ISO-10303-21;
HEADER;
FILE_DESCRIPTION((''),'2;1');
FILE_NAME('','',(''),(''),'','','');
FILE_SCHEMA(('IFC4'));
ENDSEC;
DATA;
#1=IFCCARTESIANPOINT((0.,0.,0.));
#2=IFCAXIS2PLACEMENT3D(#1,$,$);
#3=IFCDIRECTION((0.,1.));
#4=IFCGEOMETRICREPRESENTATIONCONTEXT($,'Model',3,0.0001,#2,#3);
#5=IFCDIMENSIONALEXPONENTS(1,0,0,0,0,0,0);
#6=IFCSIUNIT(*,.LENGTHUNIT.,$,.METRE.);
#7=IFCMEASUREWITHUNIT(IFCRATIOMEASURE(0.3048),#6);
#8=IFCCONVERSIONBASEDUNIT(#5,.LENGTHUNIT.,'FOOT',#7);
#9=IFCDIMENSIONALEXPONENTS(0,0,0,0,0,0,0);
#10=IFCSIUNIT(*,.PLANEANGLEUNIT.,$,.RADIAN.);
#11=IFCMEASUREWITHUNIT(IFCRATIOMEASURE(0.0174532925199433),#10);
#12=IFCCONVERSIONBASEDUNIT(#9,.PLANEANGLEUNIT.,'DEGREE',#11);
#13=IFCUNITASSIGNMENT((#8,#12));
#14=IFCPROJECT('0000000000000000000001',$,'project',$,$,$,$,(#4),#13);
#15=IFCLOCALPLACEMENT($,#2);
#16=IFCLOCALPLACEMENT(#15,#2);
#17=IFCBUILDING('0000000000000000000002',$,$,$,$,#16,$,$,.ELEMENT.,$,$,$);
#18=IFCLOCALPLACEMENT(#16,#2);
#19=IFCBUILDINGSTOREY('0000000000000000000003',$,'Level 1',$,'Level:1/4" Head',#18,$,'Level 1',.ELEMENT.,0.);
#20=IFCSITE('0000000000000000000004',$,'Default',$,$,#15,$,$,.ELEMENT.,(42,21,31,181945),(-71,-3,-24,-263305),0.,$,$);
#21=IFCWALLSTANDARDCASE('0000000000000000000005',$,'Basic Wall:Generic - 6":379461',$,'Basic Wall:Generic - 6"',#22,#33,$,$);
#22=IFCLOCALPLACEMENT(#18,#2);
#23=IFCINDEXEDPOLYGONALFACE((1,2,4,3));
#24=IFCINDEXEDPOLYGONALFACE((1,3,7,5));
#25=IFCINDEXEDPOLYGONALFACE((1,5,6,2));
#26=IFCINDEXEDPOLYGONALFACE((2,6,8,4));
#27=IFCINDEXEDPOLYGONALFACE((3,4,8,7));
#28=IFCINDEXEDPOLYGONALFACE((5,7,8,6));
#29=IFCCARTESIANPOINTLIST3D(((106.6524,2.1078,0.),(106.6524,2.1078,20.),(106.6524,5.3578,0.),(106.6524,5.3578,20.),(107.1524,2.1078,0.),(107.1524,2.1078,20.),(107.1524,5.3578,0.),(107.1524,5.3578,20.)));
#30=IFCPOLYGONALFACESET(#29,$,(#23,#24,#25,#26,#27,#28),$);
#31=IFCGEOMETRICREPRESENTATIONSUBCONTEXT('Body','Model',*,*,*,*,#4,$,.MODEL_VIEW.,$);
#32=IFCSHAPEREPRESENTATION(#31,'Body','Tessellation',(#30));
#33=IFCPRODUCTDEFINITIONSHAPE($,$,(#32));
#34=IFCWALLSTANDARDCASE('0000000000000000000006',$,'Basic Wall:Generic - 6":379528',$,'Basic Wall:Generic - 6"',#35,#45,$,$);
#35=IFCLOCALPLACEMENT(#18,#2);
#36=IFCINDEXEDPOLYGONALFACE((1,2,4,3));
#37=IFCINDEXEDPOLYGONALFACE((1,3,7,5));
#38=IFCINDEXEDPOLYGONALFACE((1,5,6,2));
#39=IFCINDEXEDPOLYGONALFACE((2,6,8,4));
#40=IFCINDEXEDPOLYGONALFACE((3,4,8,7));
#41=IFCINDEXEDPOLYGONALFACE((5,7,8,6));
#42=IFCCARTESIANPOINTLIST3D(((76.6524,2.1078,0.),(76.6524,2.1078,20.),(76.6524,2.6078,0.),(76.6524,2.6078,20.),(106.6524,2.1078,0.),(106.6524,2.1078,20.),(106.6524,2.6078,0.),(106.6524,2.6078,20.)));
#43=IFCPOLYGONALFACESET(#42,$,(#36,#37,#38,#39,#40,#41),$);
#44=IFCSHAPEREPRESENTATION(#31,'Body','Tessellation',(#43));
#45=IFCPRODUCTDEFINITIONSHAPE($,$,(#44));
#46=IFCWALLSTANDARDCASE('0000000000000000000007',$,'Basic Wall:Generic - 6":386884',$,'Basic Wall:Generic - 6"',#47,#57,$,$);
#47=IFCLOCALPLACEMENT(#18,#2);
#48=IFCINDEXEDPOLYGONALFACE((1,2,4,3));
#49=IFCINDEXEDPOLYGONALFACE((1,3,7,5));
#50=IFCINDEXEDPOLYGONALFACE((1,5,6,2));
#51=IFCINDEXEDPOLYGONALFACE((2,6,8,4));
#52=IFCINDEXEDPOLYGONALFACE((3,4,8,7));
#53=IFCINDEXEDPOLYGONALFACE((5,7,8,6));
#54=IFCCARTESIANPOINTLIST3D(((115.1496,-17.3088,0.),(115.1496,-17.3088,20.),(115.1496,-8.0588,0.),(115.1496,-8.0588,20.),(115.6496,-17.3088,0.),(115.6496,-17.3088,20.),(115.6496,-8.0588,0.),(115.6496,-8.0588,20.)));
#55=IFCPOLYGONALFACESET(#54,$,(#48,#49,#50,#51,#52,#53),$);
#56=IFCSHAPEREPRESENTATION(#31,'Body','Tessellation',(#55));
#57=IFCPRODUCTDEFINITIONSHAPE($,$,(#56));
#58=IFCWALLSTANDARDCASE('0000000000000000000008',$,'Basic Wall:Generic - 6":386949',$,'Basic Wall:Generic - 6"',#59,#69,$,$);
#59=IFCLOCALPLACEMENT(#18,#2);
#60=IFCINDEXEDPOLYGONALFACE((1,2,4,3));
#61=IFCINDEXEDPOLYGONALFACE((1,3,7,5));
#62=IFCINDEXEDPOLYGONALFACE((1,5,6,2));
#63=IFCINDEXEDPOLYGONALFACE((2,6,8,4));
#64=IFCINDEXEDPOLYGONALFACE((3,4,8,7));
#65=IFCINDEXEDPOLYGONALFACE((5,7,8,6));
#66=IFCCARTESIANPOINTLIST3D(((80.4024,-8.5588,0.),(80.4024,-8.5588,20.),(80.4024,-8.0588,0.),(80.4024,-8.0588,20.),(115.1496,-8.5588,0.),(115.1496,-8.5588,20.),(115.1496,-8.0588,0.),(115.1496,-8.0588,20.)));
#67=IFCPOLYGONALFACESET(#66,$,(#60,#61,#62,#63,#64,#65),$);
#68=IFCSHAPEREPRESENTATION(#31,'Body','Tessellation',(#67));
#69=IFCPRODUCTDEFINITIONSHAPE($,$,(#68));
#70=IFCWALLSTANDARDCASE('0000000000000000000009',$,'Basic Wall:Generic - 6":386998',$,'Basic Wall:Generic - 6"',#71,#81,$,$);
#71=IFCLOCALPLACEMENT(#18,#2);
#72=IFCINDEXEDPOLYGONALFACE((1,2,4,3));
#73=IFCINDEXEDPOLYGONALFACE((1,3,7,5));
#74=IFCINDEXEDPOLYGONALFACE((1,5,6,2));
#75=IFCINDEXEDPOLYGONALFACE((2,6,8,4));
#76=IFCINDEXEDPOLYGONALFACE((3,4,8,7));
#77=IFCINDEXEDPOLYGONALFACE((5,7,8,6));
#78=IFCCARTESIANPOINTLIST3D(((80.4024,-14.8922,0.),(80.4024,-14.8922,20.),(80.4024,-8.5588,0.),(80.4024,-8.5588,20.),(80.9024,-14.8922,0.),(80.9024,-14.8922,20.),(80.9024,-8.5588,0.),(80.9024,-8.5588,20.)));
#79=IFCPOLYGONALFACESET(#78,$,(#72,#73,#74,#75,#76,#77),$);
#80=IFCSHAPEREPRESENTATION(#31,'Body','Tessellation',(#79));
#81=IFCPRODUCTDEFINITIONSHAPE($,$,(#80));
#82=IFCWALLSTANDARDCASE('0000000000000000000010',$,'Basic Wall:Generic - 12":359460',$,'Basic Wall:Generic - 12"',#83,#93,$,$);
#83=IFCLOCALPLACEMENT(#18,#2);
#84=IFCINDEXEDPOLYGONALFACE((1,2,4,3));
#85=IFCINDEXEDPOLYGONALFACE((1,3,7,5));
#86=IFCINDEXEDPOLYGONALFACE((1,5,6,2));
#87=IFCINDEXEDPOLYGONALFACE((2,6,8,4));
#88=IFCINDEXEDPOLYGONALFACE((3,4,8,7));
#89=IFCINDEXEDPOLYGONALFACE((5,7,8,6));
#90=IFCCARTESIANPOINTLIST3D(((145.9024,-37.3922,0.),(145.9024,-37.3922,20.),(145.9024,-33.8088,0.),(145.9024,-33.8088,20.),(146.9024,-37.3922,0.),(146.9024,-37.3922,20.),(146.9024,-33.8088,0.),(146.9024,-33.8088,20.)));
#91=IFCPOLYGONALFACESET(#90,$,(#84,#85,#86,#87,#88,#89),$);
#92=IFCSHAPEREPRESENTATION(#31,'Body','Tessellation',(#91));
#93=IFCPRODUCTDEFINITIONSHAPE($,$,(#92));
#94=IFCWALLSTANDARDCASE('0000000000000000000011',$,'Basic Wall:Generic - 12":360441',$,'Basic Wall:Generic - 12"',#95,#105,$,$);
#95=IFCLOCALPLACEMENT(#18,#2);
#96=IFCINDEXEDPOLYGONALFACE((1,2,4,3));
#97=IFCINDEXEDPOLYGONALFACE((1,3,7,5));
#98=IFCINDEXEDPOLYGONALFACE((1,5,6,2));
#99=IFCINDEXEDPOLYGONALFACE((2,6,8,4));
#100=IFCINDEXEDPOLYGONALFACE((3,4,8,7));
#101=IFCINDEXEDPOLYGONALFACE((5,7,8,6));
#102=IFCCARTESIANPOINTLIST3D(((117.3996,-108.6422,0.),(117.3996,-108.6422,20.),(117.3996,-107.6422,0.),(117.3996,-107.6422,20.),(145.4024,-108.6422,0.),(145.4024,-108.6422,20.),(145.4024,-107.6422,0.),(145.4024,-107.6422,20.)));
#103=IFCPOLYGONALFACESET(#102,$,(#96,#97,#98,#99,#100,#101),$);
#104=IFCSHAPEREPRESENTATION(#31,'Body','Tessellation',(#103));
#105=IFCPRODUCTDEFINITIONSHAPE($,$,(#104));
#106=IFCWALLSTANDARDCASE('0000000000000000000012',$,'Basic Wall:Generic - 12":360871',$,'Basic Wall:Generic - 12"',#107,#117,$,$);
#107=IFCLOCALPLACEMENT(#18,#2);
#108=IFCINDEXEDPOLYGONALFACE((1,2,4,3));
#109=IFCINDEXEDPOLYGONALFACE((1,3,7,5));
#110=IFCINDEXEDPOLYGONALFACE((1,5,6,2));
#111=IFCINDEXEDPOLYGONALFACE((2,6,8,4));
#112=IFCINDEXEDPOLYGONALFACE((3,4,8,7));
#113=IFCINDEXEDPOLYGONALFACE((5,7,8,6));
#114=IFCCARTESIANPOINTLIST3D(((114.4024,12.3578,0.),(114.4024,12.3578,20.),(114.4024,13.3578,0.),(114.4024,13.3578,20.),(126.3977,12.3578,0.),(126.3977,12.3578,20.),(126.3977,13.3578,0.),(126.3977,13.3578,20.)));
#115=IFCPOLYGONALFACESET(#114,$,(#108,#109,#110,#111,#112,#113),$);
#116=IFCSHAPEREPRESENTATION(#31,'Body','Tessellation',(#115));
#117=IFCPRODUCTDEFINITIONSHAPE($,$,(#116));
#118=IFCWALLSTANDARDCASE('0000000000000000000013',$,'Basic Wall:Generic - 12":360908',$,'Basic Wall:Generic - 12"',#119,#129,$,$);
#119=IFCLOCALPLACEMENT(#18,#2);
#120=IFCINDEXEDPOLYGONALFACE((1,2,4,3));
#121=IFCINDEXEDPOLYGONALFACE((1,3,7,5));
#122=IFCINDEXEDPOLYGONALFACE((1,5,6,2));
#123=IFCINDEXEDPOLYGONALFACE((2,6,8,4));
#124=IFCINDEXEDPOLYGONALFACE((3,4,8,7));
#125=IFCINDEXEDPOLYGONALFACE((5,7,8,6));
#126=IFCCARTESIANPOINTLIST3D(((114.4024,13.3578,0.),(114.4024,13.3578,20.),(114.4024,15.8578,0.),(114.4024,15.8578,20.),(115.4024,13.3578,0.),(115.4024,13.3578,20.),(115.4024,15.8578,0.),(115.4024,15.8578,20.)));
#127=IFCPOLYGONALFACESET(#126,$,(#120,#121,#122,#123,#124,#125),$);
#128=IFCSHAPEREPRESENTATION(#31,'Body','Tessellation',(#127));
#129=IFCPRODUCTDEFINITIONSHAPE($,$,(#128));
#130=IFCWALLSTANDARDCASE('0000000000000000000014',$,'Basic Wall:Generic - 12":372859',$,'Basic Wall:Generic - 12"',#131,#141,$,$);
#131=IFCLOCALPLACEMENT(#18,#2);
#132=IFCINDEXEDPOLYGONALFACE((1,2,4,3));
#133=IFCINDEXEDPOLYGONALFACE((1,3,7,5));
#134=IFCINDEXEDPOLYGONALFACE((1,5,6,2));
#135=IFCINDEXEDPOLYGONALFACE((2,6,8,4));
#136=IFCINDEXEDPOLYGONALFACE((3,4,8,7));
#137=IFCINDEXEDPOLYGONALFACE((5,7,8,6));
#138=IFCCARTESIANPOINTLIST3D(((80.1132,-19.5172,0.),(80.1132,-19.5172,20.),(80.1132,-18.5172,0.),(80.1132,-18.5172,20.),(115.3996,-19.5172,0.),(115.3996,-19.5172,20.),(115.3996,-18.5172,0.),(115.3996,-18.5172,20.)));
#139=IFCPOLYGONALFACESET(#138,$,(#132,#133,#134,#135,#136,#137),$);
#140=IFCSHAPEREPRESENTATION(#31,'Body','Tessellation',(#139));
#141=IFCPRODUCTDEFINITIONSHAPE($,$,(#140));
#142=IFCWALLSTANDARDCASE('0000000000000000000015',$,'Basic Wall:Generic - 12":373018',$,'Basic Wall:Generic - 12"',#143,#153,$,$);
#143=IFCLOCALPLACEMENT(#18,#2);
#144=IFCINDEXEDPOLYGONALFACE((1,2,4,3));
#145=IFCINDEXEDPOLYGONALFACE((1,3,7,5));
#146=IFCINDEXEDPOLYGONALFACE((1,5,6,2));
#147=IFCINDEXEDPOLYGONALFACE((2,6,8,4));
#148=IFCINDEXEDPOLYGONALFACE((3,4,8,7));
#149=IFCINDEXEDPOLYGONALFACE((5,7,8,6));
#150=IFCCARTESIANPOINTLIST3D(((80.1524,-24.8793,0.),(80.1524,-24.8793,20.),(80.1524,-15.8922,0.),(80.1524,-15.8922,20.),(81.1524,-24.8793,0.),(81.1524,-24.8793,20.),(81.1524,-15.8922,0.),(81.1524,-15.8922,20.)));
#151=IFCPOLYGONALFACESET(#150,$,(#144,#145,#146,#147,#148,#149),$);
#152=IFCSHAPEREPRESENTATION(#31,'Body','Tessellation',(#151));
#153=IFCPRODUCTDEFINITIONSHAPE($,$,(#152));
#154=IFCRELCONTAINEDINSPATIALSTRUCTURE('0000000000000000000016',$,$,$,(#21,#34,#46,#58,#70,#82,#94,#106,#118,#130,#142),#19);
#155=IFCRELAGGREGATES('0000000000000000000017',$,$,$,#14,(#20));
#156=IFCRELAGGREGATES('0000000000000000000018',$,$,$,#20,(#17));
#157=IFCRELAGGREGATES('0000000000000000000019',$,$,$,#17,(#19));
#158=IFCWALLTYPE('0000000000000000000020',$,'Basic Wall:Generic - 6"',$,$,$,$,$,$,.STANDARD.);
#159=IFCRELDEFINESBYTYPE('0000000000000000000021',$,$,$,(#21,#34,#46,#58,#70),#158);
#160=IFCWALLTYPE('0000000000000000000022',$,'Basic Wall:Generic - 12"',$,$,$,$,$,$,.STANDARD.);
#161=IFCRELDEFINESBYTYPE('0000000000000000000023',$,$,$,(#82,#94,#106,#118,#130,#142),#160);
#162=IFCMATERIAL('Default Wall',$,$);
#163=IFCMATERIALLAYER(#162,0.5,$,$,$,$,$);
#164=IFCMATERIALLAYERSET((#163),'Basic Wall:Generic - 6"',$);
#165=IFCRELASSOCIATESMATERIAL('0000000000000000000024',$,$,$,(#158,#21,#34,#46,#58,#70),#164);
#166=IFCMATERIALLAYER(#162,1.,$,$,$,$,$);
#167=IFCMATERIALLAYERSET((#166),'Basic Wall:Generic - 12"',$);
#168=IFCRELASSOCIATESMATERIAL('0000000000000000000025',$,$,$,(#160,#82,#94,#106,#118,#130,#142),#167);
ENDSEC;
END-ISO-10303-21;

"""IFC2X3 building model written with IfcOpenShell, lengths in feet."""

from ifc_helpers import new_model, entity, si_unit, converted_unit, direction, frame, frame_2d, origin, place, context, subcontext, project, spatial, rectangle, extrude, material, layer, layer_set, layer_usage, type_object, element, save


model = new_model("IFC2X3")

# Units and contexts
model_context = context("Model", 3, precision=0.0001, world=origin(), true_north=direction((0.0, 1.0)))
body_context = subcontext(model_context, "Body", "Model", "MODEL_VIEW")
ifc_project = project(units=[converted_unit("LENGTHUNIT", "FOOT", entity("IfcRatioMeasure", 0.3048), si_unit("LENGTHUNIT", "METRE"), dimensions=[1, 0, 0, 0, 0, 0, 0]), converted_unit("PLANEANGLEUNIT", "DEGREE", entity("IfcRatioMeasure", 0.0174532925199433), si_unit("PLANEANGLEUNIT", "RADIAN"), dimensions=[0, 0, 0, 0, 0, 0, 0])], contexts=[model_context])

# Site, building, storey
site_placement = place(None, origin())
site = spatial("IfcSite", under=ifc_project, at=site_placement, Name="Default", CompositionType="ELEMENT", RefLatitude=(42, 21, 31, 181945), RefLongitude=(-71, -3, -24, -263305), RefElevation=0.0)
building_placement = place(site_placement, origin())
building = spatial("IfcBuilding", under=site, at=building_placement, CompositionType="ELEMENT")
storey_placement = place(building_placement, origin())
storey = spatial("IfcBuildingStorey", under=building, at=storey_placement, Name="Level 1", ObjectType="Level:1/4\" Head", LongName="Level 1", CompositionType="ELEMENT", Elevation=0.0)

# Walls
ifc_material = material(Name="Default Wall")
ifc_layer_1 = layer(ifc_material, 0.5)
ifc_layer_set_1 = layer_set([ifc_layer_1], Name="Basic Wall:Generic - 6\"")
wall_type_1 = type_object("IfcWallType", Name="Basic Wall:Generic - 6\"", PredefinedType="STANDARD", material=ifc_layer_set_1)
ifc_layer_usage_1 = layer_usage(ifc_layer_set_1, "AXIS2", "NEGATIVE", 0.25)
wall_1_placement = place(storey_placement, frame((106.9024, 5.3578, 0.0), z_axis=(0.0, 0.0, 1.0), x_axis=(0.0, -1.0, 0.0)))
element("IfcWallStandardCase", 1, at=wall_1_placement, inside=storey, type_object=wall_type_1, material=ifc_layer_usage_1, Name="Basic Wall:Generic - 6\":379461", ObjectType="Basic Wall:Generic - 6\"", context=body_context, shape_type="SweptSolid", body=[
    extrude(rectangle(XDim=3.25, YDim=0.5, at=frame_2d((1.625, 0.0), x_axis=(-1.0, 0.0))), origin(), (0.0, 0.0, 1.0), 20.0),
])
ifc_layer_usage_2 = layer_usage(ifc_layer_set_1, "AXIS2", "NEGATIVE", 0.25)
wall_2_placement = place(storey_placement, frame((106.6524, 2.3578, 0.0), z_axis=(0.0, 0.0, 1.0), x_axis=(-1.0, 0.0, 0.0)))
element("IfcWallStandardCase", 2, at=wall_2_placement, inside=storey, type_object=wall_type_1, material=ifc_layer_usage_2, Name="Basic Wall:Generic - 6\":379528", ObjectType="Basic Wall:Generic - 6\"", context=body_context, shape_type="SweptSolid", body=[
    extrude(rectangle(XDim=30.0, YDim=0.5, at=frame_2d((15.0, 0.0), x_axis=(-1.0, 0.0))), origin(), (0.0, 0.0, 1.0), 20.0),
])
ifc_layer_usage_3 = layer_usage(ifc_layer_set_1, "AXIS2", "NEGATIVE", 0.25)
wall_3_placement = place(storey_placement, frame((115.3996, -17.3088, 0.0), z_axis=(0.0, 0.0, 1.0), x_axis=(0.0, 1.0, 0.0)))
element("IfcWallStandardCase", 3, at=wall_3_placement, inside=storey, type_object=wall_type_1, material=ifc_layer_usage_3, Name="Basic Wall:Generic - 6\":386884", ObjectType="Basic Wall:Generic - 6\"", context=body_context, shape_type="SweptSolid", body=[
    extrude(rectangle(XDim=9.25, YDim=0.5, at=frame_2d((4.625, 0.0), x_axis=(-1.0, 0.0))), origin(), (0.0, 0.0, 1.0), 20.0),
])
ifc_layer_usage_4 = layer_usage(ifc_layer_set_1, "AXIS2", "NEGATIVE", 0.25)
wall_4_placement = place(storey_placement, frame((115.1496, -8.3088, 0.0), z_axis=(0.0, 0.0, 1.0), x_axis=(-1.0, 0.0, 0.0)))
element("IfcWallStandardCase", 4, at=wall_4_placement, inside=storey, type_object=wall_type_1, material=ifc_layer_usage_4, Name="Basic Wall:Generic - 6\":386949", ObjectType="Basic Wall:Generic - 6\"", context=body_context, shape_type="SweptSolid", body=[
    extrude(rectangle(XDim=34.7472, YDim=0.5, at=frame_2d((17.3736, 0.0), x_axis=(-1.0, 0.0))), origin(), (0.0, 0.0, 1.0), 20.0),
])
ifc_layer_usage_5 = layer_usage(ifc_layer_set_1, "AXIS2", "NEGATIVE", 0.25)
wall_5_placement = place(storey_placement, frame((80.6524, -8.5588, 0.0), z_axis=(0.0, 0.0, 1.0), x_axis=(0.0, -1.0, 0.0)))
element("IfcWallStandardCase", 5, at=wall_5_placement, inside=storey, type_object=wall_type_1, material=ifc_layer_usage_5, Name="Basic Wall:Generic - 6\":386998", ObjectType="Basic Wall:Generic - 6\"", context=body_context, shape_type="SweptSolid", body=[
    extrude(rectangle(XDim=6.3333, YDim=0.5, at=frame_2d((3.1667, 0.0), x_axis=(-1.0, 0.0))), origin(), (0.0, 0.0, 1.0), 20.0),
])
ifc_layer_2 = layer(ifc_material, 1.0)
ifc_layer_set_2 = layer_set([ifc_layer_2], Name="Basic Wall:Generic - 12\"")
ifc_layer_usage_6 = layer_usage(ifc_layer_set_2, "AXIS2", "NEGATIVE", 0.5)
wall_type_2 = type_object("IfcWallType", Name="Basic Wall:Generic - 12\"", PredefinedType="STANDARD", material=ifc_layer_set_2)
wall_6_placement = place(storey_placement, frame((146.4024, -37.3922, 0.0), z_axis=(0.0, 0.0, 1.0), x_axis=(0.0, 1.0, 0.0)))
element("IfcWallStandardCase", 6, at=wall_6_placement, inside=storey, type_object=wall_type_2, material=ifc_layer_usage_6, Name="Basic Wall:Generic - 12\":359460", ObjectType="Basic Wall:Generic - 12\"", context=body_context, shape_type="SweptSolid", body=[
    extrude(rectangle(XDim=3.5833, YDim=1.0, at=frame_2d((1.7917, 0.0), x_axis=(-1.0, 0.0))), origin(), (0.0, 0.0, 1.0), 20.0),
])
ifc_layer_usage_7 = layer_usage(ifc_layer_set_2, "AXIS2", "NEGATIVE", 0.5)
wall_7_placement = place(storey_placement, frame((117.3996, -108.1422, 0.0)))
element("IfcWallStandardCase", 7, at=wall_7_placement, inside=storey, type_object=wall_type_2, material=ifc_layer_usage_7, Name="Basic Wall:Generic - 12\":360441", ObjectType="Basic Wall:Generic - 12\"", context=body_context, shape_type="SweptSolid", body=[
    extrude(rectangle(XDim=28.0028, YDim=1.0, at=frame_2d((14.0014, 0.0), x_axis=(-1.0, 0.0))), origin(), (0.0, 0.0, 1.0), 20.0),
])
ifc_layer_usage_8 = layer_usage(ifc_layer_set_2, "AXIS2", "NEGATIVE", 0.5)
wall_8_placement = place(storey_placement, frame((126.3977, 12.8578, 0.0), z_axis=(0.0, 0.0, 1.0), x_axis=(-1.0, 0.0, 0.0)))
element("IfcWallStandardCase", 8, at=wall_8_placement, inside=storey, type_object=wall_type_2, material=ifc_layer_usage_8, Name="Basic Wall:Generic - 12\":360871", ObjectType="Basic Wall:Generic - 12\"", context=body_context, shape_type="SweptSolid", body=[
    extrude(rectangle(XDim=11.9953, YDim=1.0, at=frame_2d((5.9977, 0.0), x_axis=(-1.0, 0.0))), origin(), (0.0, 0.0, 1.0), 20.0),
])
ifc_layer_usage_9 = layer_usage(ifc_layer_set_2, "AXIS2", "NEGATIVE", 0.5)
wall_9_placement = place(storey_placement, frame((114.9024, 13.3578, 0.0), z_axis=(0.0, 0.0, 1.0), x_axis=(0.0, 1.0, 0.0)))
element("IfcWallStandardCase", 9, at=wall_9_placement, inside=storey, type_object=wall_type_2, material=ifc_layer_usage_9, Name="Basic Wall:Generic - 12\":360908", ObjectType="Basic Wall:Generic - 12\"", context=body_context, shape_type="SweptSolid", body=[
    extrude(rectangle(XDim=2.5, YDim=1.0, at=frame_2d((1.25, 0.0), x_axis=(-1.0, 0.0))), origin(), (0.0, 0.0, 1.0), 20.0),
])
ifc_layer_usage_10 = layer_usage(ifc_layer_set_2, "AXIS2", "NEGATIVE", 0.5)
wall_10_placement = place(storey_placement, frame((115.3996, -19.0172, 0.0), z_axis=(0.0, 0.0, 1.0), x_axis=(-1.0, 0.0, 0.0)))
element("IfcWallStandardCase", 10, at=wall_10_placement, inside=storey, type_object=wall_type_2, material=ifc_layer_usage_10, Name="Basic Wall:Generic - 12\":372859", ObjectType="Basic Wall:Generic - 12\"", context=body_context, shape_type="SweptSolid", body=[
    extrude(rectangle(XDim=35.2864, YDim=1.0, at=frame_2d((17.6432, 0.0), x_axis=(-1.0, 0.0))), origin(), (0.0, 0.0, 1.0), 20.0),
])
ifc_layer_usage_11 = layer_usage(ifc_layer_set_2, "AXIS2", "NEGATIVE", 0.5)
wall_11_placement = place(storey_placement, frame((80.6524, -15.8922, 0.0), z_axis=(0.0, 0.0, 1.0), x_axis=(0.0, -1.0, 0.0)))
element("IfcWallStandardCase", 11, at=wall_11_placement, inside=storey, type_object=wall_type_2, material=ifc_layer_usage_11, Name="Basic Wall:Generic - 12\":373018", ObjectType="Basic Wall:Generic - 12\"", context=body_context, shape_type="SweptSolid", body=[
    extrude(rectangle(XDim=8.9871, YDim=1.0, at=frame_2d((4.4936, 0.0), x_axis=(-1.0, 0.0))), origin(), (0.0, 0.0, 1.0), 20.0),
])

save(model, "model.ifc")
